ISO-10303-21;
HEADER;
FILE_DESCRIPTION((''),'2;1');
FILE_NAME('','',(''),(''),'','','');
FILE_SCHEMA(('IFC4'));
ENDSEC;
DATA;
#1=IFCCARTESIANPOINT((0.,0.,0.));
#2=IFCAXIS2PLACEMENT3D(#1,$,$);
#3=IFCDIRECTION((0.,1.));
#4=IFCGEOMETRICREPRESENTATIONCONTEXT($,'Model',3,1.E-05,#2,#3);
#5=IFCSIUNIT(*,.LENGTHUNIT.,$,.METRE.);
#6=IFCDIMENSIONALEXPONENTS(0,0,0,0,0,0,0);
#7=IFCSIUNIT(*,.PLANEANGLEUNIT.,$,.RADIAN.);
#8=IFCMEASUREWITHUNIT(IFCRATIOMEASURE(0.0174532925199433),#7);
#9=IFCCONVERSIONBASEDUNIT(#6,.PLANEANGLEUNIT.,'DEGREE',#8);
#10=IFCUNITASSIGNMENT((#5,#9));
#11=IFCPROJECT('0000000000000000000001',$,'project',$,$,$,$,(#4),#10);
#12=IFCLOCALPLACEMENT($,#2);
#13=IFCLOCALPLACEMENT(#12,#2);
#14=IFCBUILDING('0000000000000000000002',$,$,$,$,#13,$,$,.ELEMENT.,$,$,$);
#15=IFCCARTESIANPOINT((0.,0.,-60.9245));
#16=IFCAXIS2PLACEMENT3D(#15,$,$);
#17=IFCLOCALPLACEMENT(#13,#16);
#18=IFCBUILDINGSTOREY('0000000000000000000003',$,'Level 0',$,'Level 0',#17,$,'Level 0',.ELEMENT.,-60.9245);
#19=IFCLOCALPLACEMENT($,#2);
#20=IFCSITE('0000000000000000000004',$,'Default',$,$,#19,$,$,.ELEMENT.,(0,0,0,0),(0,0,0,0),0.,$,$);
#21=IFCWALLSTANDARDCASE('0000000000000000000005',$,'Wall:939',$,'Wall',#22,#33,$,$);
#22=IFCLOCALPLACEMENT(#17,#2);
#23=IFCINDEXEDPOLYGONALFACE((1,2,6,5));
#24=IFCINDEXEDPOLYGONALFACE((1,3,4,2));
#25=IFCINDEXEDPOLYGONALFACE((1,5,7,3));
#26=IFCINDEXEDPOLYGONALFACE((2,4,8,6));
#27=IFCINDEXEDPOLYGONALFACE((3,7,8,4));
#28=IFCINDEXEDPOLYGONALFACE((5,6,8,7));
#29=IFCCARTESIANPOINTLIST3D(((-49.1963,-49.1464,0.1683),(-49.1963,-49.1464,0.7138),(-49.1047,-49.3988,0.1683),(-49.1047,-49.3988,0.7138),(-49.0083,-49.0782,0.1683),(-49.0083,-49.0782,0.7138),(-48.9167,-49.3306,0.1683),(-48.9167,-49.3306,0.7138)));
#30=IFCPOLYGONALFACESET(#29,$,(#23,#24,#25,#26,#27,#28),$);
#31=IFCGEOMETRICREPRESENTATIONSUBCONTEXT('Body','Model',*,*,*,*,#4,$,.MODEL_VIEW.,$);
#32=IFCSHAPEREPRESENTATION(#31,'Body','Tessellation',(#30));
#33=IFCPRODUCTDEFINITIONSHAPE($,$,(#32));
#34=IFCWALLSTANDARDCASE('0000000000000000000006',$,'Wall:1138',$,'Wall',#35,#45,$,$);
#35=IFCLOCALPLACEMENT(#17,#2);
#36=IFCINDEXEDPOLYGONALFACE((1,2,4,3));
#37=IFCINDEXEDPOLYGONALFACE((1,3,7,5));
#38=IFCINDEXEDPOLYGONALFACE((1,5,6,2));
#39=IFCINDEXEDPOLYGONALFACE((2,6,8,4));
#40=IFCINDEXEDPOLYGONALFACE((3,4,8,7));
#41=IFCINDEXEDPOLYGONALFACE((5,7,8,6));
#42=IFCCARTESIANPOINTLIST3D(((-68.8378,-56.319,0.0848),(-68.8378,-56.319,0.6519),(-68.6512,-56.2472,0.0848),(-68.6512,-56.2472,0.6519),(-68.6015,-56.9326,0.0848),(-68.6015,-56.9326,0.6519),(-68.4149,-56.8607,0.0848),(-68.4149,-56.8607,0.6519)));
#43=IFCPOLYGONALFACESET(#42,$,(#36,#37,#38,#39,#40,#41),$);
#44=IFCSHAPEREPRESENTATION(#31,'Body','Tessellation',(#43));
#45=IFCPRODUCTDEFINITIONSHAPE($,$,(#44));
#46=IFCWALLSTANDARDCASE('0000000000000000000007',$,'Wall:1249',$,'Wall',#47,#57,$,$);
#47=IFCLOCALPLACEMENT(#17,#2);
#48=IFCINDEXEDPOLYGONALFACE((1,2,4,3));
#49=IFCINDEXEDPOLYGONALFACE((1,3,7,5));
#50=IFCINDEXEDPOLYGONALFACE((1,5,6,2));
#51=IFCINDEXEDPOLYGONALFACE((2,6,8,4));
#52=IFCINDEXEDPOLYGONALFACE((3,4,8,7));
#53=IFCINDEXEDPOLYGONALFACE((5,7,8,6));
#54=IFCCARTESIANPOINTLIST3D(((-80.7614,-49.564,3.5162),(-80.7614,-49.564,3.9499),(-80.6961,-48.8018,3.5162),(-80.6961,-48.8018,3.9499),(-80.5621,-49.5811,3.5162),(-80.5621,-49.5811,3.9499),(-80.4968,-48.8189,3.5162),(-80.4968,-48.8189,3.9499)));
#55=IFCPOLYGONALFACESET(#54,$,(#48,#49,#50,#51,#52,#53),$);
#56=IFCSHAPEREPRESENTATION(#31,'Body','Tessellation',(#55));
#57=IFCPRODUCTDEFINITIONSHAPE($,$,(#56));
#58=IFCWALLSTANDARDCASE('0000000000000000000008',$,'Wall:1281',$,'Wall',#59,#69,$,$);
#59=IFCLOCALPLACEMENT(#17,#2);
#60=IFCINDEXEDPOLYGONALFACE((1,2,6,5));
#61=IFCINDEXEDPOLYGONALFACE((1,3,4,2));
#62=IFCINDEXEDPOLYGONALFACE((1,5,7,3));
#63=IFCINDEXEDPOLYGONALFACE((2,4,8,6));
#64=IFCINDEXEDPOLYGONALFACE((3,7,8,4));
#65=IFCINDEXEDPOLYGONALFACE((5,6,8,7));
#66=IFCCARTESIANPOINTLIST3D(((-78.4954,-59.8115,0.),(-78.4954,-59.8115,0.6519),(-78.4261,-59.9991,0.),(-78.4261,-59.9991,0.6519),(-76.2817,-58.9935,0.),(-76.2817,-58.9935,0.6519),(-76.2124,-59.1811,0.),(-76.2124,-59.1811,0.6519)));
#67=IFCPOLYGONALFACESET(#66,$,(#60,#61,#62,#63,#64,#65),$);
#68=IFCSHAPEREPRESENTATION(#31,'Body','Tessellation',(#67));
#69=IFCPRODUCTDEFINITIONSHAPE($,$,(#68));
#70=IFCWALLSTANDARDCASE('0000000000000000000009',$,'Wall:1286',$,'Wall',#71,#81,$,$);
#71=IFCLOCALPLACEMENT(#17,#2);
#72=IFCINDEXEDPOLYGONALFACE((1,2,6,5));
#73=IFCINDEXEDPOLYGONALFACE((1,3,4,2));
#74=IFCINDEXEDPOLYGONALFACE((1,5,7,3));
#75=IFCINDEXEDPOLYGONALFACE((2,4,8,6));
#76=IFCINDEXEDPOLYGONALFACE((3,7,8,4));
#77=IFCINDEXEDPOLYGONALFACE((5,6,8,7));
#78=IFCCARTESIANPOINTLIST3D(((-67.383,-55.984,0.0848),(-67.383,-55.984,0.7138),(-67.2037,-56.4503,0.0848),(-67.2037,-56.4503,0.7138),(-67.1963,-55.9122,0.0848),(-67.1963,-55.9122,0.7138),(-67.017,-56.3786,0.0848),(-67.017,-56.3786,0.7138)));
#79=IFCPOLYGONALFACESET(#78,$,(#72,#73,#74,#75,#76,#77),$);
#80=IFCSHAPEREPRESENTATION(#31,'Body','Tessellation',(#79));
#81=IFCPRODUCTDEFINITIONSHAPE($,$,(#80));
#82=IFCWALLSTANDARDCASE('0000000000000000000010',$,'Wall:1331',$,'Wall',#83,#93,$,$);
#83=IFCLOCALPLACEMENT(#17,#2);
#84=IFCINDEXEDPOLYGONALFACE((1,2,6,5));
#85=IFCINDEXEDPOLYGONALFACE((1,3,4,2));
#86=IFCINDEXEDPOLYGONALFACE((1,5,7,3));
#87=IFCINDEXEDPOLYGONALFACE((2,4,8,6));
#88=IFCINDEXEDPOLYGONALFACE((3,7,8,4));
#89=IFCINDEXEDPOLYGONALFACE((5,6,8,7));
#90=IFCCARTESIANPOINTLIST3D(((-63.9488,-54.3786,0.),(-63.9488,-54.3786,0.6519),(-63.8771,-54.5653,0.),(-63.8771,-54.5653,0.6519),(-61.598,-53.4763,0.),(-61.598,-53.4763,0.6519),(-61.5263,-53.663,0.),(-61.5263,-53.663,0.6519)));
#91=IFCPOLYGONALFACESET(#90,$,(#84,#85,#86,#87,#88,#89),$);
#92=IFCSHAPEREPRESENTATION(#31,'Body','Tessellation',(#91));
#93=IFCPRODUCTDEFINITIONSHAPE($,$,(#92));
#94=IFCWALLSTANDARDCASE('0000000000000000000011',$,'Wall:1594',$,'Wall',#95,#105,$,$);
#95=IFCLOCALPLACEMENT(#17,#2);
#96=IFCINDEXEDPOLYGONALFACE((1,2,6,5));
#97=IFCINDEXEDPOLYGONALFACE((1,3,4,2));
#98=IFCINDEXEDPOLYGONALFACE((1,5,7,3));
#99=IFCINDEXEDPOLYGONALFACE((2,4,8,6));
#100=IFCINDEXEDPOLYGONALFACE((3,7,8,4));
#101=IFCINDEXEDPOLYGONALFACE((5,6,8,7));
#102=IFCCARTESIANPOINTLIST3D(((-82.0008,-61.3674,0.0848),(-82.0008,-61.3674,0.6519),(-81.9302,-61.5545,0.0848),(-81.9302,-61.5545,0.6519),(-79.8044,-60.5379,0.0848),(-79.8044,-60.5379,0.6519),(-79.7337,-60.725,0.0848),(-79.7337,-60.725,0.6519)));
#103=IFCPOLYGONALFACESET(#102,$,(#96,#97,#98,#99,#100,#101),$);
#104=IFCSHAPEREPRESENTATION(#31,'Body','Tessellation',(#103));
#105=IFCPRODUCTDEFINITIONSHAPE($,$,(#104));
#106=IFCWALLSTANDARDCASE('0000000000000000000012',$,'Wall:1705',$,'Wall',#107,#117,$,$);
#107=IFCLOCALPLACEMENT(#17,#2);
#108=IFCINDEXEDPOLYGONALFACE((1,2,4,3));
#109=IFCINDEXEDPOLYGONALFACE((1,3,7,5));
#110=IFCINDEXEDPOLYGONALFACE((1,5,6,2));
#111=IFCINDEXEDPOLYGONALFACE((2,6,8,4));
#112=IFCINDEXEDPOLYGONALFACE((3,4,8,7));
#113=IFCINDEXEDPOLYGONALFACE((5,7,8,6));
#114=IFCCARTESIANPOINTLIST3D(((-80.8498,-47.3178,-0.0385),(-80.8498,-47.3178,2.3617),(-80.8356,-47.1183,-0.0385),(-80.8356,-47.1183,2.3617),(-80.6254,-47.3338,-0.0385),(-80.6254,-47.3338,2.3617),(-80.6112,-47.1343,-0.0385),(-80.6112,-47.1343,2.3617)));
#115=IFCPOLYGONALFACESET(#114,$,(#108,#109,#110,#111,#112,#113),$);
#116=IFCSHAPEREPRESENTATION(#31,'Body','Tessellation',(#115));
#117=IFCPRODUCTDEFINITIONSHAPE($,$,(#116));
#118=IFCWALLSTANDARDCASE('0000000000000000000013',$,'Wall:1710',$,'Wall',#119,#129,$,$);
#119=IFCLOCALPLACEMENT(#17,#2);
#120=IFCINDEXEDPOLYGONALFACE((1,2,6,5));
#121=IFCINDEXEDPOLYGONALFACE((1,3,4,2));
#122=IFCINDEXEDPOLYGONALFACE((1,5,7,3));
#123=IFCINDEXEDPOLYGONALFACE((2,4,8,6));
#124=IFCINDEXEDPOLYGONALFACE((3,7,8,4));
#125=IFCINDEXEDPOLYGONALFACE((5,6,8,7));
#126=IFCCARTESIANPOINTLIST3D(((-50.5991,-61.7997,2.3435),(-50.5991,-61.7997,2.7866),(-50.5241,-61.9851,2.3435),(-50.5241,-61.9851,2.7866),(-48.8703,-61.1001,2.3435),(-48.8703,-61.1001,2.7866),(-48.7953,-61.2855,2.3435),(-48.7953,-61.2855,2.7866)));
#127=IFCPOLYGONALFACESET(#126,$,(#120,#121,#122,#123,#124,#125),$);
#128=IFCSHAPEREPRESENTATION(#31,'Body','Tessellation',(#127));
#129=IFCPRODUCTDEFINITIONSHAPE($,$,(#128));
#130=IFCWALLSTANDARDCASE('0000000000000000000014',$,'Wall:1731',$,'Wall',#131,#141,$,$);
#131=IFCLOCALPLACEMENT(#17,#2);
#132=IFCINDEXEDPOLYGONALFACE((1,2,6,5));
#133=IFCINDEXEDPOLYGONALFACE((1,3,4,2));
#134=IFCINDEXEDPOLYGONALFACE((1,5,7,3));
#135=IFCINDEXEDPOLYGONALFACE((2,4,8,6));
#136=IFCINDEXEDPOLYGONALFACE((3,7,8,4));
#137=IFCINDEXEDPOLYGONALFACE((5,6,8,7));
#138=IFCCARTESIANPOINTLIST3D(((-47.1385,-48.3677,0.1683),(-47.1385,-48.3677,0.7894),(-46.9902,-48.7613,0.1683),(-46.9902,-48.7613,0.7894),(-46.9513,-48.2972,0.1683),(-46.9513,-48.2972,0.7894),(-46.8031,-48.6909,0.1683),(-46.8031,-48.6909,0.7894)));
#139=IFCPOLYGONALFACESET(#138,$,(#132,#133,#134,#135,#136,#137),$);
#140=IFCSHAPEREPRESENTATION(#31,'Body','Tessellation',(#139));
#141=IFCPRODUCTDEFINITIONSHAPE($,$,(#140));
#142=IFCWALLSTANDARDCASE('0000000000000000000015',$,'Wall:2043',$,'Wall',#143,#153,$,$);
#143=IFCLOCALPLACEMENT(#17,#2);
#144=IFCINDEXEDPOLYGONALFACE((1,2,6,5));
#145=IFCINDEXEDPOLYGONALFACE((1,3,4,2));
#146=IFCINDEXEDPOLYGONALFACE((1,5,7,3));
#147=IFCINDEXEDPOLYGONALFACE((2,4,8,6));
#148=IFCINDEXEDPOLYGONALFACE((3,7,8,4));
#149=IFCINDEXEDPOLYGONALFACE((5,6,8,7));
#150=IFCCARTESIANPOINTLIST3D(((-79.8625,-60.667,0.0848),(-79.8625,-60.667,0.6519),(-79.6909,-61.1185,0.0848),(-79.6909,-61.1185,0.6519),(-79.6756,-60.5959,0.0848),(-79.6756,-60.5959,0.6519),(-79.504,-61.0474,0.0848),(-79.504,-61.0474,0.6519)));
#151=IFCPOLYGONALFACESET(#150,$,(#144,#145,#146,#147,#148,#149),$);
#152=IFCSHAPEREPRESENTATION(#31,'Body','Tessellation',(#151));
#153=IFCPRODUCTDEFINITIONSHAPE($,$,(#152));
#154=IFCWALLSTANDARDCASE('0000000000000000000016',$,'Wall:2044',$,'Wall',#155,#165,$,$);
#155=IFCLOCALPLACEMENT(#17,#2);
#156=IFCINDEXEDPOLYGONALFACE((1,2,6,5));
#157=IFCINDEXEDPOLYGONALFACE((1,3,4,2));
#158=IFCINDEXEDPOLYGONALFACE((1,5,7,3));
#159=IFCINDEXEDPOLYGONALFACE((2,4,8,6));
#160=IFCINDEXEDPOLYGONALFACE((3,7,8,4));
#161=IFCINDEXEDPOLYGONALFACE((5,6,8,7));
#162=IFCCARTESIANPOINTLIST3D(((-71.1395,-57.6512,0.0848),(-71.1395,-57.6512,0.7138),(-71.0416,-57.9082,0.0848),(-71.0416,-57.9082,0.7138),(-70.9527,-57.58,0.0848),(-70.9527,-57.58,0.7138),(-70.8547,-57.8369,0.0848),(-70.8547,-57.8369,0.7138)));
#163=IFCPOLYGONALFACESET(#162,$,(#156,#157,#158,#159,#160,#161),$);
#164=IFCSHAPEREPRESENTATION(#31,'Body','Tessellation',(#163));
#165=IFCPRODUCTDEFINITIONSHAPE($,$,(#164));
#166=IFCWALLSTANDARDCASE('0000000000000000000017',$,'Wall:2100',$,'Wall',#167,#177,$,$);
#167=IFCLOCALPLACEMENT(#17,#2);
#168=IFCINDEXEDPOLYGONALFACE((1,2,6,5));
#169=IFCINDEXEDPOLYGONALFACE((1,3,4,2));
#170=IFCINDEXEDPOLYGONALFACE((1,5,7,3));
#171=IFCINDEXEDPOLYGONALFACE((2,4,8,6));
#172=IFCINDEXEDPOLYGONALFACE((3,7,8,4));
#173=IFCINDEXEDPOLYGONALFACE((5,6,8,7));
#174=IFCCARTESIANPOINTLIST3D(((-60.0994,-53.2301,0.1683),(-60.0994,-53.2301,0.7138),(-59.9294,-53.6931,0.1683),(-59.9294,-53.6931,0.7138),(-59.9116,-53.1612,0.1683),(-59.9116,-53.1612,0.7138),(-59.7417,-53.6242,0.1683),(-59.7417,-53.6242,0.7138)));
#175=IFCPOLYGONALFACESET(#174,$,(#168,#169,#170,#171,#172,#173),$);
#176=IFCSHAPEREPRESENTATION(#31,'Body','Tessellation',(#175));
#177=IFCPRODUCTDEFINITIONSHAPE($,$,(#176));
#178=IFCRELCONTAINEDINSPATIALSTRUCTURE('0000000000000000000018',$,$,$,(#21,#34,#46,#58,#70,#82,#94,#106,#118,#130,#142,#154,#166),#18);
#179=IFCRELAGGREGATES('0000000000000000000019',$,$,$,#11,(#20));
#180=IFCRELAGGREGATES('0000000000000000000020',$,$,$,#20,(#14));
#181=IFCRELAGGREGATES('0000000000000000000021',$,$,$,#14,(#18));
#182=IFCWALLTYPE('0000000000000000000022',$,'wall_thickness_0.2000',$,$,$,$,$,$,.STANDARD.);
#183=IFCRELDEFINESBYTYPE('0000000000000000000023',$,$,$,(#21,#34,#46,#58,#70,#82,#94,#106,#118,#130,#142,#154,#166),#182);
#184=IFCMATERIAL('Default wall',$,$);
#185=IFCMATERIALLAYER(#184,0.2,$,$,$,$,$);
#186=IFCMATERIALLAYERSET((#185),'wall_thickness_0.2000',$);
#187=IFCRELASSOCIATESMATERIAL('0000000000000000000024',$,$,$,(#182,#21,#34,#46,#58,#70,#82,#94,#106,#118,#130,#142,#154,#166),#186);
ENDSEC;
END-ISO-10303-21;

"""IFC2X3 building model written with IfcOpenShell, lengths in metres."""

from ifc_helpers import new_model, entity, si_unit, converted_unit, direction, frame, origin, place, context, subcontext, project, spatial, polyline, outline, extrude, material, layer, layer_set, layer_usage, type_object, element, save


model = new_model("IFC2X3")

# Units and contexts
model_context = context("Model", 3, precision=1e-05, world=origin(), true_north=direction((0.0, 1.0)))
body_context = subcontext(model_context, "Body", "Model", "MODEL_VIEW")
ifc_project = project(units=[si_unit("LENGTHUNIT", "METRE"), converted_unit("PLANEANGLEUNIT", "DEGREE", entity("IfcRatioMeasure", 0.0174532925199433), si_unit("PLANEANGLEUNIT", "RADIAN"), dimensions=[0, 0, 0, 0, 0, 0, 0])], contexts=[model_context])

# Site, building, storey
site_placement = place(None, origin())
site = spatial("IfcSite", under=ifc_project, at=site_placement, Name="Default", CompositionType="ELEMENT", RefLatitude=(0, 0, 0, 0), RefLongitude=(0, 0, 0, 0), RefElevation=0.0)
placement_1 = place(None, origin())
building_placement = place(placement_1, origin())
building = spatial("IfcBuilding", under=site, at=building_placement, CompositionType="ELEMENT")
storey_placement = place(building_placement, frame((0.0, 0.0, -60.9245)))
storey = spatial("IfcBuildingStorey", under=building, at=storey_placement, Name="Level 0", ObjectType="Level 0", LongName="Level 0", CompositionType="ELEMENT", Elevation=-60.9245)

# Walls
ifc_material = material(Name="Default wall")
ifc_layer = layer(ifc_material, 0.2)
ifc_layer_set = layer_set([ifc_layer], Name="wall_thickness_0.2000")
ifc_layer_usage = layer_usage(ifc_layer_set, "AXIS2", "POSITIVE", -0.1)
wall_type = type_object("IfcWallType", Name="wall_thickness_0.2000", PredefinedType="STANDARD", material=ifc_layer_set)
placement_2 = place(building_placement, frame((0.0, 0.0, -60.7562)))
wall_1_placement = place(placement_2, frame((-49.0107, -49.3647, 0.0), z_axis=(0.0, 0.0, 1.0), x_axis=(-0.341014, 0.940058, 0.0)))
element("IfcWallStandardCase", 1, at=wall_1_placement, inside=storey, type_object=wall_type, material=ifc_layer_usage, Name="Wall:939", ObjectType="Wall", context=body_context, shape_type="SweptSolid", body=[
    extrude(outline(polyline([(0.2685, -0.1), (0.2685, 0.1), (0.0, 0.1), (0.0, -0.1), (0.2685, -0.1)])), origin(), (0.0, 0.0, 1.0), 0.5454),
])
placement_3 = place(building_placement, frame((0.0, 0.0, -60.8397)))
wall_2_placement = place(placement_3, frame((-68.5082, -56.8967, 0.0), z_axis=(0.0, 0.0, 1.0), x_axis=(-0.359411, 0.93318, 0.0)))
element("IfcWallStandardCase", 2, at=wall_2_placement, inside=storey, type_object=wall_type, material=ifc_layer_usage, Name="Wall:1138", ObjectType="Wall", context=body_context, shape_type="SweptSolid", body=[
    extrude(outline(polyline([(0.6575, -0.1), (0.6575, 0.1), (0.0, 0.1), (0.0, -0.1), (0.6575, -0.1)])), origin(), (0.0, 0.0, 1.0), 0.5671),
])
placement_4 = place(building_placement, frame((0.0, 0.0, -57.4083)))
wall_3_placement = place(placement_4, frame((-80.5964, -48.8104, 0.0), z_axis=(0.0, 0.0, 1.0), x_axis=(-0.0854, -0.996347, 0.0)))
element("IfcWallStandardCase", 3, at=wall_3_placement, inside=storey, type_object=wall_type, material=ifc_layer_usage, Name="Wall:1249", ObjectType="Wall", context=body_context, shape_type="SweptSolid", body=[
    extrude(outline(polyline([(0.765, -0.1), (0.765, 0.1), (0.0, 0.1), (0.0, -0.1), (0.765, -0.1)])), origin(), (0.0, 0.0, 1.0), 0.4337),
])
wall_4_placement = place(storey_placement, frame((-78.4608, -59.9053, 0.0), z_axis=(0.0, 0.0, 1.0), x_axis=(0.938011, 0.346605, 0.0)))
element("IfcWallStandardCase", 4, at=wall_4_placement, inside=storey, type_object=wall_type, material=ifc_layer_usage, Name="Wall:1281", ObjectType="Wall", context=body_context, shape_type="SweptSolid", body=[
    extrude(outline(polyline([(2.36, -0.1), (2.36, 0.1), (0.0, 0.1), (0.0, -0.1), (2.36, -0.1)])), origin(), (0.0, 0.0, 1.0), 0.6519),
])
placement_5 = place(building_placement, frame((0.0, 0.0, -60.8397)))
wall_5_placement = place(placement_5, frame((-67.1104, -56.4145, 0.0), z_axis=(0.0, 0.0, 1.0), x_axis=(-0.358838, 0.9334, 0.0)))
element("IfcWallStandardCase", 5, at=wall_5_placement, inside=storey, type_object=wall_type, material=ifc_layer_usage, Name="Wall:1286", ObjectType="Wall", context=body_context, shape_type="SweptSolid", body=[
    extrude(outline(polyline([(0.4996, -0.1), (0.4996, 0.1), (0.0, 0.1), (0.0, -0.1), (0.4996, -0.1)])), origin(), (0.0, 0.0, 1.0), 0.629),
])
wall_6_placement = place(storey_placement, frame((-63.9129, -54.472, 0.0), z_axis=(0.0, 0.0, 1.0), x_axis=(0.933589, 0.358346, 0.0)))
element("IfcWallStandardCase", 6, at=wall_6_placement, inside=storey, type_object=wall_type, material=ifc_layer_usage, Name="Wall:1331", ObjectType="Wall", context=body_context, shape_type="SweptSolid", body=[
    extrude(outline(polyline([(2.518, -0.1), (2.518, 0.1), (0.0, 0.1), (0.0, -0.1), (2.518, -0.1)])), origin(), (0.0, 0.0, 1.0), 0.6519),
])
placement_6 = place(building_placement, frame((0.0, 0.0, -60.8397)))
wall_7_placement = place(placement_6, frame((-81.9655, -61.461, 0.0), z_axis=(0.0, 0.0, 1.0), x_axis=(0.935505, 0.353314, 0.0)))
element("IfcWallStandardCase", 7, at=wall_7_placement, inside=storey, type_object=wall_type, material=ifc_layer_usage, Name="Wall:1594", ObjectType="Wall", context=body_context, shape_type="SweptSolid", body=[
    extrude(outline(polyline([(2.3478, -0.1), (2.3478, 0.1), (0.0, 0.1), (0.0, -0.1), (2.3478, -0.1)])), origin(), (0.0, 0.0, 1.0), 0.5671),
])
placement_7 = place(building_placement, frame((0.0, 0.0, -60.963)))
wall_8_placement = place(placement_7, frame((-80.6183, -47.2341, 0.0), z_axis=(0.0, 0.0, 1.0), x_axis=(-0.997477, 0.070987, 0.0)))
element("IfcWallStandardCase", 8, at=wall_8_placement, inside=storey, type_object=wall_type, material=ifc_layer_usage, Name="Wall:1705", ObjectType="Wall", context=body_context, shape_type="SweptSolid", body=[
    extrude(outline(polyline([(0.225, -0.1), (0.225, 0.1), (0.0, 0.1), (0.0, -0.1), (0.225, -0.1)])), origin(), (0.0, 0.0, 1.0), 2.4003),
])
placement_8 = place(building_placement, frame((0.0, 0.0, -58.581)))
wall_9_placement = place(placement_8, frame((-50.5616, -61.8924, 0.0), z_axis=(0.0, 0.0, 1.0), x_axis=(0.926971, 0.375133, 0.0)))
element("IfcWallStandardCase", 9, at=wall_9_placement, inside=storey, type_object=wall_type, material=ifc_layer_usage, Name="Wall:1710", ObjectType="Wall", context=body_context, shape_type="SweptSolid", body=[
    extrude(outline(polyline([(1.865, -0.1), (1.865, 0.1), (0.0, 0.1), (0.0, -0.1), (1.865, -0.1)])), origin(), (0.0, 0.0, 1.0), 0.4431),
])
placement_9 = place(building_placement, frame((0.0, 0.0, -60.7562)))
wall_10_placement = place(placement_9, frame((-46.8967, -48.7261, 0.0), z_axis=(0.0, 0.0, 1.0), x_axis=(-0.352326, 0.935877, 0.0)))
element("IfcWallStandardCase", 10, at=wall_10_placement, inside=storey, type_object=wall_type, material=ifc_layer_usage, Name="Wall:1731", ObjectType="Wall", context=body_context, shape_type="SweptSolid", body=[
    extrude(outline(polyline([(0.4207, -0.1), (0.4207, 0.1), (0.0, 0.1), (0.0, -0.1), (0.4207, -0.1)])), origin(), (0.0, 0.0, 1.0), 0.6211),
])
placement_10 = place(building_placement, frame((0.0, 0.0, -60.8397)))
wall_11_placement = place(placement_10, frame((-79.5974, -61.083, 0.0), z_axis=(0.0, 0.0, 1.0), x_axis=(-0.355331, 0.934741, 0.0)))
element("IfcWallStandardCase", 11, at=wall_11_placement, inside=storey, type_object=wall_type, material=ifc_layer_usage, Name="Wall:2043", ObjectType="Wall", context=body_context, shape_type="SweptSolid", body=[
    extrude(outline(polyline([(0.483, -0.1), (0.483, 0.1), (0.0, 0.1), (0.0, -0.1), (0.483, -0.1)])), origin(), (0.0, 0.0, 1.0), 0.5671),
])
placement_11 = place(building_placement, frame((0.0, 0.0, -60.8397)))
wall_12_placement = place(placement_11, frame((-70.9482, -57.8726, 0.0), z_axis=(0.0, 0.0, 1.0), x_axis=(-0.35614, 0.934433, 0.0)))
element("IfcWallStandardCase", 12, at=wall_12_placement, inside=storey, type_object=wall_type, material=ifc_layer_usage, Name="Wall:2044", ObjectType="Wall", context=body_context, shape_type="SweptSolid", body=[
    extrude(outline(polyline([(0.275, -0.1), (0.275, 0.1), (0.0, 0.1), (0.0, -0.1), (0.275, -0.1)])), origin(), (0.0, 0.0, 1.0), 0.629),
])
placement_12 = place(building_placement, frame((0.0, 0.0, -60.7562)))
wall_13_placement = place(placement_12, frame((-60.0055, -53.1956, 0.0), z_axis=(0.0, 0.0, 1.0), x_axis=(0.344548, -0.938769, 0.0)))
element("IfcWallStandardCase", 13, at=wall_13_placement, inside=storey, type_object=wall_type, material=ifc_layer_usage, Name="Wall:2100", ObjectType="Wall", context=body_context, shape_type="SweptSolid", body=[
    extrude(outline(polyline([(0.4932, -0.1), (0.4932, 0.1), (0.0, 0.1), (0.0, -0.1), (0.4932, -0.1)])), origin(), (0.0, 0.0, 1.0), 0.5454),
])

save(model, "model.ifc")
